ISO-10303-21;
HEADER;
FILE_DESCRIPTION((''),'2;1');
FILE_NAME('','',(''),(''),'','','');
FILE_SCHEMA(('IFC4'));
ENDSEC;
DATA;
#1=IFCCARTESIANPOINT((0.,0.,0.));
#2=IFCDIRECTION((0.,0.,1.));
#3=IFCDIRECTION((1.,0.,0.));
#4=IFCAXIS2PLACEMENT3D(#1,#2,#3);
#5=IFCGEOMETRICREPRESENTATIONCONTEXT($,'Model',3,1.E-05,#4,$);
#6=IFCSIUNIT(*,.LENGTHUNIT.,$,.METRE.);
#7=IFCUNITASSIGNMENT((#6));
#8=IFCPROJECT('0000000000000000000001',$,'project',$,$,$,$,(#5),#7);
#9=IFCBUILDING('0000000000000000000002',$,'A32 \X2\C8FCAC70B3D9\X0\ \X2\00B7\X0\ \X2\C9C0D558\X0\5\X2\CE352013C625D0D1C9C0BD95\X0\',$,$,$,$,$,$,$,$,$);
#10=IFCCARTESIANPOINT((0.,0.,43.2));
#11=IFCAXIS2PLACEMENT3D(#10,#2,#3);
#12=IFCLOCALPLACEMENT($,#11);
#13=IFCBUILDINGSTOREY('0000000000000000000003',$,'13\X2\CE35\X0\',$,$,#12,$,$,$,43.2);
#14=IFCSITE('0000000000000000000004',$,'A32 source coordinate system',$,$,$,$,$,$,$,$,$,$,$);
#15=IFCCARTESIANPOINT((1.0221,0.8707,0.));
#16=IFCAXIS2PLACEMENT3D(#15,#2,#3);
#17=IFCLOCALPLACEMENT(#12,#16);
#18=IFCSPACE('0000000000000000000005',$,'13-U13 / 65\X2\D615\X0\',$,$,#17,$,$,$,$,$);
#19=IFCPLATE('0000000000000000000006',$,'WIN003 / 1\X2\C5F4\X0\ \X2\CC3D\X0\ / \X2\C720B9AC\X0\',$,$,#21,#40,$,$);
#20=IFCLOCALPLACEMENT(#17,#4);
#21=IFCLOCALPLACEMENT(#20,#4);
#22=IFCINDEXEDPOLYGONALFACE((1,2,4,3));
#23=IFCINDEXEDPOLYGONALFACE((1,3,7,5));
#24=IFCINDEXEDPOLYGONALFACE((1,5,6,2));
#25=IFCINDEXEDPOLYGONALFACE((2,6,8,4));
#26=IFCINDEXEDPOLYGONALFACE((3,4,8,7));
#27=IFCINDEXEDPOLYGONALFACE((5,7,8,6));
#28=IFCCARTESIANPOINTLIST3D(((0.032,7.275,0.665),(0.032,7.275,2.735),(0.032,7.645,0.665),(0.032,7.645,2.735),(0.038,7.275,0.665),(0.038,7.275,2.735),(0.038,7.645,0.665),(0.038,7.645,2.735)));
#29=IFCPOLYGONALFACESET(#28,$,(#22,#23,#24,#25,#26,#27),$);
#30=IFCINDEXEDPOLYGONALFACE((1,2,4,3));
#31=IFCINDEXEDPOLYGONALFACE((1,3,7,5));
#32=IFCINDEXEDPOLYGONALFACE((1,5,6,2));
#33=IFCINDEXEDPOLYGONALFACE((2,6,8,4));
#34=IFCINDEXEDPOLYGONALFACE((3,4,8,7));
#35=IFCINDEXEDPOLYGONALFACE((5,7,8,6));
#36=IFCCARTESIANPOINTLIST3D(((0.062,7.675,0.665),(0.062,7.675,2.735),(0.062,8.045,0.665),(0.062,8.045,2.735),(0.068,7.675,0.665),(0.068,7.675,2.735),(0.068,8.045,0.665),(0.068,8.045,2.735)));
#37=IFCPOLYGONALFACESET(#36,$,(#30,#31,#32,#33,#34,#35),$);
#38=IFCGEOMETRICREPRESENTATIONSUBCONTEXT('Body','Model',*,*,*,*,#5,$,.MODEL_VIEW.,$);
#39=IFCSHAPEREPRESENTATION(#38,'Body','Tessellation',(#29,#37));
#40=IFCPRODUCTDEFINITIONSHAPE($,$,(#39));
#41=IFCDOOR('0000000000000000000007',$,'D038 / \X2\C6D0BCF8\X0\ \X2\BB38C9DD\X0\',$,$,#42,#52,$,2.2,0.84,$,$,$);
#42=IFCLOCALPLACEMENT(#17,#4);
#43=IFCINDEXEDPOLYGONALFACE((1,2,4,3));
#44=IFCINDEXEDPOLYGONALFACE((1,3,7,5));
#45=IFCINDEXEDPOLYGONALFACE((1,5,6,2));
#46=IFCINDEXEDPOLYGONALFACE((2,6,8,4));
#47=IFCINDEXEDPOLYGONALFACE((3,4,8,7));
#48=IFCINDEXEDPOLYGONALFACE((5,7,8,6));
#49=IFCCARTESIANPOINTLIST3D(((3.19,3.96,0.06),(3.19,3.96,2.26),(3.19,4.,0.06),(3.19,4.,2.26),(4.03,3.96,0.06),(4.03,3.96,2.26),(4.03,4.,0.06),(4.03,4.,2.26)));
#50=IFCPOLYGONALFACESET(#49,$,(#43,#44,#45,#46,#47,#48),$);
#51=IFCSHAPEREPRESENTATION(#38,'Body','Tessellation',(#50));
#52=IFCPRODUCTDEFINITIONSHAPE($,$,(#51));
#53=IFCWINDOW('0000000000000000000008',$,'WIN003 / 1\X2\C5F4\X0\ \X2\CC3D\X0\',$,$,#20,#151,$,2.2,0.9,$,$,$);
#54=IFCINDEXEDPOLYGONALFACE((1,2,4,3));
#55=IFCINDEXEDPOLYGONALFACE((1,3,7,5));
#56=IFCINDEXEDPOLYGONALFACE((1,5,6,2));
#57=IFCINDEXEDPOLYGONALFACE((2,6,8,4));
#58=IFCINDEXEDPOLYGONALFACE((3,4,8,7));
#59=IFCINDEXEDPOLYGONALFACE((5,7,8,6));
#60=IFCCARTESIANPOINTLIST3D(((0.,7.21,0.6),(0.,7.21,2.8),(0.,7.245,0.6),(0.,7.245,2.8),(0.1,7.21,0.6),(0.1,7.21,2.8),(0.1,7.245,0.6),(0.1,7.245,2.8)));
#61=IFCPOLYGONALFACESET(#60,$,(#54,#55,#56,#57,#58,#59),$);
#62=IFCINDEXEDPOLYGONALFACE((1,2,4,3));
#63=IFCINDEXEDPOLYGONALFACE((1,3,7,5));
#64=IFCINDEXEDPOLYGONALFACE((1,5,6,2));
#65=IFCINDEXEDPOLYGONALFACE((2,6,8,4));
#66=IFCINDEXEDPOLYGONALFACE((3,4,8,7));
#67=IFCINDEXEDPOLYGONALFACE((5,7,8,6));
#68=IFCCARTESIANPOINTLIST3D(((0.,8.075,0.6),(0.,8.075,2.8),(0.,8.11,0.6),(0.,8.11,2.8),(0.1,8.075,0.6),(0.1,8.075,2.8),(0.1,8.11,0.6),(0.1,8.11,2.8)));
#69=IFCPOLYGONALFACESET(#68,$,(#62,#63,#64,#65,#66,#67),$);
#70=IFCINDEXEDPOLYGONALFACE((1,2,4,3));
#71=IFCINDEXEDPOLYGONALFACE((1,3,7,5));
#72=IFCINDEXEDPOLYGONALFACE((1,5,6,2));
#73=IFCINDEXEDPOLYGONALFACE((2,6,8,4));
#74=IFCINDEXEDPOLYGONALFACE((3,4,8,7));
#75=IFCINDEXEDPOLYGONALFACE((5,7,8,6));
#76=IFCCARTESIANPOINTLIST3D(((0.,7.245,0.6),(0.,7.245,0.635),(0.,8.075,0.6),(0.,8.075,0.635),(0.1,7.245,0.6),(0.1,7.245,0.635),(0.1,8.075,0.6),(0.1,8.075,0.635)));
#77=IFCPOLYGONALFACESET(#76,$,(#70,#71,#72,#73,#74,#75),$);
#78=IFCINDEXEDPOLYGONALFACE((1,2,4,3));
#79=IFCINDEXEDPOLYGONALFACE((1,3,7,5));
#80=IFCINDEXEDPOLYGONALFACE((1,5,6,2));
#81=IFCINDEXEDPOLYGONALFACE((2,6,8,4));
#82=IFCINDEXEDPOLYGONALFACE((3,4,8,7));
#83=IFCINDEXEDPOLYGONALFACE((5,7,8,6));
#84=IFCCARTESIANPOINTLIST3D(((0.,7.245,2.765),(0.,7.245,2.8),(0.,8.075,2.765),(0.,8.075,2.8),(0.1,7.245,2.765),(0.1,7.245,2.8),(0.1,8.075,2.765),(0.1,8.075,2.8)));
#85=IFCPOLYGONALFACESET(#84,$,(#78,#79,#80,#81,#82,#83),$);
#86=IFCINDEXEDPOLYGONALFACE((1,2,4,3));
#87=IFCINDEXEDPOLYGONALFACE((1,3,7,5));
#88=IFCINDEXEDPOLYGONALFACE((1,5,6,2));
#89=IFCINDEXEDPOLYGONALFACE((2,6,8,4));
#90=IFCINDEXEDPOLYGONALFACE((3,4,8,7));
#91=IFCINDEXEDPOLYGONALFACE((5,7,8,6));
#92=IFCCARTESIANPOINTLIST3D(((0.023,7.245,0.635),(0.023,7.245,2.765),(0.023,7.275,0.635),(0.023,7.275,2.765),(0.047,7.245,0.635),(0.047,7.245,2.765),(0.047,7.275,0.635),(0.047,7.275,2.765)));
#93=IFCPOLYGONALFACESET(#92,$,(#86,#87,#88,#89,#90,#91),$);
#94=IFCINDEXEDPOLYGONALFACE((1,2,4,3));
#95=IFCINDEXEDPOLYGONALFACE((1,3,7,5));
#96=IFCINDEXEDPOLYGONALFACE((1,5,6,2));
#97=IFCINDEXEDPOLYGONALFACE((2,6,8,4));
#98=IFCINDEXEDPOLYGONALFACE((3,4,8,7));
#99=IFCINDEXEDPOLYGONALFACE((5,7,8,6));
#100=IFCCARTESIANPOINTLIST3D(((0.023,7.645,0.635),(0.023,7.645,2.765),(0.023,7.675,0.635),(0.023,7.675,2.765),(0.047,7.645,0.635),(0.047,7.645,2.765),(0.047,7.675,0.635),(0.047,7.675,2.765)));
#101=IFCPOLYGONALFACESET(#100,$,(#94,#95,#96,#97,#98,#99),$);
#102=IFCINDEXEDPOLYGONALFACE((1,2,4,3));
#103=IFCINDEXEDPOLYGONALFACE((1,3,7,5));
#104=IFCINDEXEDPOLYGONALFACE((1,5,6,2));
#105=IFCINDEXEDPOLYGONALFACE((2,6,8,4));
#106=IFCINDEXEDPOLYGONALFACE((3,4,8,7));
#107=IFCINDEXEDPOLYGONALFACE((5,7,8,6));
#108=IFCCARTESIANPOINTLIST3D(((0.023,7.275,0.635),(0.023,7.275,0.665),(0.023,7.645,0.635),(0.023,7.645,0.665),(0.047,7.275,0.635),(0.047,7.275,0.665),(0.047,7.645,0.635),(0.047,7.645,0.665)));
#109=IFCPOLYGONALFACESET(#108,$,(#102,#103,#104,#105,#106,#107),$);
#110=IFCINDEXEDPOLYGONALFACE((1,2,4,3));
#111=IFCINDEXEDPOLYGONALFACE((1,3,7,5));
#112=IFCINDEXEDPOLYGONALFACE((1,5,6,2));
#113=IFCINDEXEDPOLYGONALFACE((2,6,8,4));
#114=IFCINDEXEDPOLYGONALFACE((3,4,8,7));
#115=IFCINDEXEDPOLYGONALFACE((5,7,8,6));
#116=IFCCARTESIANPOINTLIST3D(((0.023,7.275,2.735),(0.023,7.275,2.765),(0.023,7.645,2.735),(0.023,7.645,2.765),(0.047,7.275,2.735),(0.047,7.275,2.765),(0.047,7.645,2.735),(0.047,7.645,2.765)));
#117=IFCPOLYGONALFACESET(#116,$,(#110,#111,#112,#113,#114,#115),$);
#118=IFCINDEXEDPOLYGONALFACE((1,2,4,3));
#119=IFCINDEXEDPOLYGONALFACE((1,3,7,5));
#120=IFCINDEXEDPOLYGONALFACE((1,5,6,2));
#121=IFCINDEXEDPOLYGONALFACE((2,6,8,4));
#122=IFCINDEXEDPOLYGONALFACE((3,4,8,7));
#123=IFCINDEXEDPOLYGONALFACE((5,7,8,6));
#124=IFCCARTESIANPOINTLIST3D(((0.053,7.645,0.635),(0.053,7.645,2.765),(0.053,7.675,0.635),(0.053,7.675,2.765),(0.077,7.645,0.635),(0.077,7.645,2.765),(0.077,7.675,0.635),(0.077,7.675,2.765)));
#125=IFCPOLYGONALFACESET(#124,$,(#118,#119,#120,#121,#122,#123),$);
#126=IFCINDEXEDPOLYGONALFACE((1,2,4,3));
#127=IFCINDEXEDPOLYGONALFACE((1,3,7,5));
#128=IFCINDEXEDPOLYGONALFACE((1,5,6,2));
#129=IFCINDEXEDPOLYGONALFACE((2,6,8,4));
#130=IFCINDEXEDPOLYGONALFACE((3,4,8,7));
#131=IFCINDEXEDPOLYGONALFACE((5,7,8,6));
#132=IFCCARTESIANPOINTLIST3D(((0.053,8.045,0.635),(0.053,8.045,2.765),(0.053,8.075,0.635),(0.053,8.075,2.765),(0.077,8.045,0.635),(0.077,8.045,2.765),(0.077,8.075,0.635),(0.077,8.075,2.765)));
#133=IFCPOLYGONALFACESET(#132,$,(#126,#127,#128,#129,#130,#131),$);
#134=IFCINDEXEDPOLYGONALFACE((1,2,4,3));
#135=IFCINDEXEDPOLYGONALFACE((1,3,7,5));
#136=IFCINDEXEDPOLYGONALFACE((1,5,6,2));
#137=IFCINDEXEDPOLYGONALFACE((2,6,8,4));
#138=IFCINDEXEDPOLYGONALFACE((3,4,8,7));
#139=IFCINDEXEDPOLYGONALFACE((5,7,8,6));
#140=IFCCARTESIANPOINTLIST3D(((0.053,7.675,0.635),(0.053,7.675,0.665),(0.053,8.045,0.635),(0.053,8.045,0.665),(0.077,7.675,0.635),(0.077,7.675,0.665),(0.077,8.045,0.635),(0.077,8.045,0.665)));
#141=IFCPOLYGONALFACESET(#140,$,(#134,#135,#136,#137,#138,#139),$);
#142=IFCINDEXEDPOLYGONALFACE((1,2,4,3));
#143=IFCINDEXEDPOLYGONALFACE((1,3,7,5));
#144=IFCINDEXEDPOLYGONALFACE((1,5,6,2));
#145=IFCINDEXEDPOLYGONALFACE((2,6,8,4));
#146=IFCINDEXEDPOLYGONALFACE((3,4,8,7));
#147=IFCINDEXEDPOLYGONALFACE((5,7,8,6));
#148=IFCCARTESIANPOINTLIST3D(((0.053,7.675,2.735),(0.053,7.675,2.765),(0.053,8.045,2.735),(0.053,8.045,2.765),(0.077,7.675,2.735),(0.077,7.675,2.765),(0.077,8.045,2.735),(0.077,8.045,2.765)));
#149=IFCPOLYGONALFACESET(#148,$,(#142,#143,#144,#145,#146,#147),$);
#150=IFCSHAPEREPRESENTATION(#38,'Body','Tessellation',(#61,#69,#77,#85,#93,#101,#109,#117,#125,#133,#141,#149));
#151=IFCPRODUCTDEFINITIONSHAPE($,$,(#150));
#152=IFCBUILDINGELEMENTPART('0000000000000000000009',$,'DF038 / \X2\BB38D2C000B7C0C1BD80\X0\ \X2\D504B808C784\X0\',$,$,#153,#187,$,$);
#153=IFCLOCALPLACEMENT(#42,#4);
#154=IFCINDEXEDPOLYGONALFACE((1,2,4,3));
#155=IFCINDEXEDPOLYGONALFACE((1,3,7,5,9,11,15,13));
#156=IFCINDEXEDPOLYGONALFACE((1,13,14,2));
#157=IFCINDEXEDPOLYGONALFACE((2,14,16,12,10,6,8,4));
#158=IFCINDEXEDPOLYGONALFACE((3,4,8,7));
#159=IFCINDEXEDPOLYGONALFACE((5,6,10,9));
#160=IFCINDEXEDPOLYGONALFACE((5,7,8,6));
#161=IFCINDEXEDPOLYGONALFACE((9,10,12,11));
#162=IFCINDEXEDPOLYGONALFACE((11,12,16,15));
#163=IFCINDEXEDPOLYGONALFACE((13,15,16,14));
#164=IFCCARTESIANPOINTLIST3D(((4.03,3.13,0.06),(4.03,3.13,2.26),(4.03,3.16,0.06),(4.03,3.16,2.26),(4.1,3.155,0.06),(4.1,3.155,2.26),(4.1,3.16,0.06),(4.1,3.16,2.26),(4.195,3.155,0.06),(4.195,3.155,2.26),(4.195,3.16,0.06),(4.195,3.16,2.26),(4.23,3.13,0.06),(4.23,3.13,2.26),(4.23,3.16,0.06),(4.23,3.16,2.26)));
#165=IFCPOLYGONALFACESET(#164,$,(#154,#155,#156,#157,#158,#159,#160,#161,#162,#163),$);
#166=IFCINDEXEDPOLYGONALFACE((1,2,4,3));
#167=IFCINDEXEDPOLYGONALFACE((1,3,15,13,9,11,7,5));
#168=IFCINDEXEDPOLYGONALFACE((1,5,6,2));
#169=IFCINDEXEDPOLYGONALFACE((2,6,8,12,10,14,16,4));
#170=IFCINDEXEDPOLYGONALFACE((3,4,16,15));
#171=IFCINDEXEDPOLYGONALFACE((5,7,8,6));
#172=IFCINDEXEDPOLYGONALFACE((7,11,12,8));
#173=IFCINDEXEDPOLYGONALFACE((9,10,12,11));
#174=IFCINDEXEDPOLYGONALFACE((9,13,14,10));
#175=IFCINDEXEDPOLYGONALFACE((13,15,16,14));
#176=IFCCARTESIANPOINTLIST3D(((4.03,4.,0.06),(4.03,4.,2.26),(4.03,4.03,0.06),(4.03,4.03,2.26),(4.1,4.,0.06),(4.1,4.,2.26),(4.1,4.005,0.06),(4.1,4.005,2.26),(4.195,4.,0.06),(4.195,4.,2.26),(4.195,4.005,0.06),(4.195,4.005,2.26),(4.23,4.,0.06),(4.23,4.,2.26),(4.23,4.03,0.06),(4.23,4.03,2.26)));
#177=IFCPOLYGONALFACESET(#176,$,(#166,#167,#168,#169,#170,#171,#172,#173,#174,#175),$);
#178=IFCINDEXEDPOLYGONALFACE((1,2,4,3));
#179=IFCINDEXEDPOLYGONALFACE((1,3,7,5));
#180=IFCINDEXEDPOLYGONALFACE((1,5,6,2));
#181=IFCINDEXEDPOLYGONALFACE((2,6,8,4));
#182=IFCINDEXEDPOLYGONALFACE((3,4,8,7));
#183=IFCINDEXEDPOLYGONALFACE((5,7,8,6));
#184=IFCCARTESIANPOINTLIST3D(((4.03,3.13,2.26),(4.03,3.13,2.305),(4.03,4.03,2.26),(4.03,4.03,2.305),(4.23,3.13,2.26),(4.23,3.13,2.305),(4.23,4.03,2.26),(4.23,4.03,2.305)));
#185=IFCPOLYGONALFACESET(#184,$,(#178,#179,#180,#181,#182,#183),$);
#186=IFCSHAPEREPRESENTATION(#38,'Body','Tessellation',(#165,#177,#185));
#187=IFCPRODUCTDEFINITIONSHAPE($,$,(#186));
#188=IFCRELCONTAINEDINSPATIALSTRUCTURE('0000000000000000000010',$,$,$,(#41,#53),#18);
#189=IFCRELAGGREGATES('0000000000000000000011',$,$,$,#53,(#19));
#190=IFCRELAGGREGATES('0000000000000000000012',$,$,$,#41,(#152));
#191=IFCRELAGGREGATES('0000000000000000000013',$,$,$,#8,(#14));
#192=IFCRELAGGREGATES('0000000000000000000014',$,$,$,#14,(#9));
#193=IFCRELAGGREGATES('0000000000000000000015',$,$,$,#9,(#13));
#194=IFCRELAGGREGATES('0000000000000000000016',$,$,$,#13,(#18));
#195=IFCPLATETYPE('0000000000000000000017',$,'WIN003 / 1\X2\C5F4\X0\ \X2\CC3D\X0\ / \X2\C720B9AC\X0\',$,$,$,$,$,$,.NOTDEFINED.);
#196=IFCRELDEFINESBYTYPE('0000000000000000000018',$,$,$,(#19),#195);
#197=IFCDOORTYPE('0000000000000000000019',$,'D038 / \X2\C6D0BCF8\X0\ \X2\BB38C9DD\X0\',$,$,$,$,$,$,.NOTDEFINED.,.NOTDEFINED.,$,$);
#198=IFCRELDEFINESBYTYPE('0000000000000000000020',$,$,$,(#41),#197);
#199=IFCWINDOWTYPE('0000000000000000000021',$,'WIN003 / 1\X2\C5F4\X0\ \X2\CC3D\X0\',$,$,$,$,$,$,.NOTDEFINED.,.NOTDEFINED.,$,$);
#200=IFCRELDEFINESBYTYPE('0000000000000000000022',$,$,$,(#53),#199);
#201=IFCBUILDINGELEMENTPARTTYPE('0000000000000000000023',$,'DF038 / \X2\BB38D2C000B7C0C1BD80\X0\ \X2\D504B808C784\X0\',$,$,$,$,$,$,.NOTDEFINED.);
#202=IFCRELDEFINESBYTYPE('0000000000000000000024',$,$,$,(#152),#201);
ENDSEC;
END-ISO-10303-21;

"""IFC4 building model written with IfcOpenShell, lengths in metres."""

from ifc_helpers import new_model, si_unit, frame, origin, origin_with_axes, place, context, subcontext, project, spatial, polyline, outline, extrude, source, transform, mapped, type_object, type_shapes, element, aggregate, save


model = new_model("IFC4")

# Units and contexts
model_context = context("Model", 3, precision=1e-05, world=origin_with_axes())
body_context = subcontext(model_context, "Body", "Model", "MODEL_VIEW")
ifc_project = project(units=[si_unit("LENGTHUNIT", "METRE")], contexts=[model_context])

# Plate
storey_placement = place(None, frame((0.0, 0.0, 43.2), z_axis=(0.0, 0.0, 1.0), x_axis=(1.0, 0.0, 0.0)))
space_placement = place(storey_placement, frame((1.0221, 0.8707, 0.0), z_axis=(0.0, 0.0, 1.0), x_axis=(1.0, 0.0, 0.0)))
plate_type_1 = type_object("IfcPlateType", Name="WIN003 / 1열 창 / 유리", PredefinedType="NOTDEFINED")
shared_shape_1 = source(origin(), body_context, "Body", "SweptSolid", [
    extrude(outline(polyline([(0.032, 7.275), (0.032, 7.645), (0.038, 7.645), (0.038, 7.275), (0.032, 7.275)])), frame((0.0, 0.0, 0.665)), (0.0, 0.0, 1.0), 2.07),
    extrude(outline(polyline([(0.062, 7.675), (0.062, 8.045), (0.068, 8.045), (0.068, 7.675), (0.062, 7.675)])), frame((0.0, 0.0, 0.665)), (0.0, 0.0, 1.0), 2.07),
])
type_shapes(plate_type_1, [shared_shape_1])
window_1_placement = place(space_placement, origin_with_axes())
plate_1_placement = place(window_1_placement, origin_with_axes())
plate_1 = element("IfcPlate", 1, at=plate_1_placement, type_object=plate_type_1, Name="WIN003 / 1열 창 / 유리", context=body_context, shape_type="MappedRepresentation", body=[
    mapped(shared_shape_1, transform((0.0, 0.0, 0.0), scale=1.0)),
])

# Site, building, storey, space
site = spatial("IfcSite", under=ifc_project, Name="A32 source coordinate system")
building = spatial("IfcBuilding", under=site, Name="A32 주거동 · 지하5층–옥탑지붕")
storey = spatial("IfcBuildingStorey", under=building, at=storey_placement, Name="13층", Elevation=43.2)
space = spatial("IfcSpace", under=storey, at=space_placement, Name="13-U13 / 65형")

# Door
door_type_1 = type_object("IfcDoorType", Name="D038 / 원본 문짝", OperationType="NOTDEFINED", PredefinedType="NOTDEFINED")
shared_shape_2 = source(origin(), body_context, "Body", "SweptSolid", [
    extrude(outline(polyline([(3.19, 3.96), (3.19, 4.0), (4.03, 4.0), (4.03, 3.96), (3.19, 3.96)])), frame((0.0, 0.0, 0.06)), (0.0, 0.0, 1.0), 2.2),
])
type_shapes(door_type_1, [shared_shape_2])
door_1_placement = place(space_placement, origin_with_axes())
door_1 = element("IfcDoor", 2, at=door_1_placement, inside=space, type_object=door_type_1, Name="D038 / 원본 문짝", OverallHeight=2.2, OverallWidth=0.84, context=body_context, shape_type="MappedRepresentation", body=[
    mapped(shared_shape_2, transform((0.0, 0.0, 0.0), scale=1.0)),
])

# Window
window_type_1 = type_object("IfcWindowType", Name="WIN003 / 1열 창", PartitioningType="NOTDEFINED", PredefinedType="NOTDEFINED")
shared_shape_3 = source(origin(), body_context, "Body", "SweptSolid", [
    extrude(outline(polyline([(0.0, 7.21), (0.0, 7.245), (0.1, 7.245), (0.1, 7.21), (0.0, 7.21)])), frame((0.0, 0.0, 0.6)), (0.0, 0.0, 1.0), 2.2),
    extrude(outline(polyline([(0.0, 8.075), (0.0, 8.11), (0.1, 8.11), (0.1, 8.075), (0.0, 8.075)])), frame((0.0, 0.0, 0.6)), (0.0, 0.0, 1.0), 2.2),
    extrude(outline(polyline([(0.0, 7.245), (0.0, 8.075), (0.1, 8.075), (0.1, 7.245), (0.0, 7.245)])), frame((0.0, 0.0, 0.6)), (0.0, 0.0, 1.0), 0.035),
    extrude(outline(polyline([(0.0, 7.245), (0.0, 8.075), (0.1, 8.075), (0.1, 7.245), (0.0, 7.245)])), frame((0.0, 0.0, 2.765)), (0.0, 0.0, 1.0), 0.035),
    extrude(outline(polyline([(0.023, 7.245), (0.023, 7.275), (0.047, 7.275), (0.047, 7.245), (0.023, 7.245)])), frame((0.0, 0.0, 0.635)), (0.0, 0.0, 1.0), 2.13),
    extrude(outline(polyline([(0.023, 7.645), (0.023, 7.675), (0.047, 7.675), (0.047, 7.645), (0.023, 7.645)])), frame((0.0, 0.0, 0.635)), (0.0, 0.0, 1.0), 2.13),
    extrude(outline(polyline([(0.023, 7.275), (0.023, 7.645), (0.047, 7.645), (0.047, 7.275), (0.023, 7.275)])), frame((0.0, 0.0, 0.635)), (0.0, 0.0, 1.0), 0.03),
    extrude(outline(polyline([(0.023, 7.275), (0.023, 7.645), (0.047, 7.645), (0.047, 7.275), (0.023, 7.275)])), frame((0.0, 0.0, 2.735)), (0.0, 0.0, 1.0), 0.03),
    extrude(outline(polyline([(0.053, 7.645), (0.053, 7.675), (0.077, 7.675), (0.077, 7.645), (0.053, 7.645)])), frame((0.0, 0.0, 0.635)), (0.0, 0.0, 1.0), 2.13),
    extrude(outline(polyline([(0.053, 8.045), (0.053, 8.075), (0.077, 8.075), (0.077, 8.045), (0.053, 8.045)])), frame((0.0, 0.0, 0.635)), (0.0, 0.0, 1.0), 2.13),
    extrude(outline(polyline([(0.053, 7.675), (0.053, 8.045), (0.077, 8.045), (0.077, 7.675), (0.053, 7.675)])), frame((0.0, 0.0, 0.635)), (0.0, 0.0, 1.0), 0.03),
    extrude(outline(polyline([(0.053, 7.675), (0.053, 8.045), (0.077, 8.045), (0.077, 7.675), (0.053, 7.675)])), frame((0.0, 0.0, 2.735)), (0.0, 0.0, 1.0), 0.03),
])
type_shapes(window_type_1, [shared_shape_3])
window_1 = element("IfcWindow", 3, at=window_1_placement, inside=space, type_object=window_type_1, Name="WIN003 / 1열 창", OverallHeight=2.2, OverallWidth=0.9, context=body_context, shape_type="MappedRepresentation", body=[
    mapped(shared_shape_3, transform((0.0, 0.0, 0.0), scale=1.0)),
])
aggregate(window_1, [plate_1])

# Building element part
building_element_part_type_1 = type_object("IfcBuildingElementPartType", Name="DF038 / 문틀·상부 프레임", PredefinedType="NOTDEFINED")
shared_shape_4 = source(origin(), body_context, "Body", "SweptSolid", [
    extrude(outline(polyline([(4.03, 3.16), (4.1, 3.16), (4.1, 3.155), (4.195, 3.155), (4.195, 3.16), (4.23, 3.16), (4.23, 3.13), (4.03, 3.13), (4.03, 3.16)])), frame((0.0, 0.0, 0.06)), (0.0, 0.0, 1.0), 2.2),
    extrude(outline(polyline([(4.23, 4.03), (4.23, 4.0), (4.195, 4.0), (4.195, 4.005), (4.1, 4.005), (4.1, 4.0), (4.03, 4.0), (4.03, 4.03), (4.23, 4.03)])), frame((0.0, 0.0, 0.06)), (0.0, 0.0, 1.0), 2.2),
    extrude(outline(polyline([(4.03, 3.13), (4.03, 4.03), (4.23, 4.03), (4.23, 3.13), (4.03, 3.13)])), frame((0.0, 0.0, 2.26)), (0.0, 0.0, 1.0), 0.045),
])
type_shapes(building_element_part_type_1, [shared_shape_4])
building_element_part_1_placement = place(door_1_placement, origin_with_axes())
building_element_part_1 = element("IfcBuildingElementPart", 4, at=building_element_part_1_placement, type_object=building_element_part_type_1, Name="DF038 / 문틀·상부 프레임", context=body_context, shape_type="MappedRepresentation", body=[
    mapped(shared_shape_4, transform((0.0, 0.0, 0.0), scale=1.0)),
])
aggregate(door_1, [building_element_part_1])

save(model, "model.ifc")
